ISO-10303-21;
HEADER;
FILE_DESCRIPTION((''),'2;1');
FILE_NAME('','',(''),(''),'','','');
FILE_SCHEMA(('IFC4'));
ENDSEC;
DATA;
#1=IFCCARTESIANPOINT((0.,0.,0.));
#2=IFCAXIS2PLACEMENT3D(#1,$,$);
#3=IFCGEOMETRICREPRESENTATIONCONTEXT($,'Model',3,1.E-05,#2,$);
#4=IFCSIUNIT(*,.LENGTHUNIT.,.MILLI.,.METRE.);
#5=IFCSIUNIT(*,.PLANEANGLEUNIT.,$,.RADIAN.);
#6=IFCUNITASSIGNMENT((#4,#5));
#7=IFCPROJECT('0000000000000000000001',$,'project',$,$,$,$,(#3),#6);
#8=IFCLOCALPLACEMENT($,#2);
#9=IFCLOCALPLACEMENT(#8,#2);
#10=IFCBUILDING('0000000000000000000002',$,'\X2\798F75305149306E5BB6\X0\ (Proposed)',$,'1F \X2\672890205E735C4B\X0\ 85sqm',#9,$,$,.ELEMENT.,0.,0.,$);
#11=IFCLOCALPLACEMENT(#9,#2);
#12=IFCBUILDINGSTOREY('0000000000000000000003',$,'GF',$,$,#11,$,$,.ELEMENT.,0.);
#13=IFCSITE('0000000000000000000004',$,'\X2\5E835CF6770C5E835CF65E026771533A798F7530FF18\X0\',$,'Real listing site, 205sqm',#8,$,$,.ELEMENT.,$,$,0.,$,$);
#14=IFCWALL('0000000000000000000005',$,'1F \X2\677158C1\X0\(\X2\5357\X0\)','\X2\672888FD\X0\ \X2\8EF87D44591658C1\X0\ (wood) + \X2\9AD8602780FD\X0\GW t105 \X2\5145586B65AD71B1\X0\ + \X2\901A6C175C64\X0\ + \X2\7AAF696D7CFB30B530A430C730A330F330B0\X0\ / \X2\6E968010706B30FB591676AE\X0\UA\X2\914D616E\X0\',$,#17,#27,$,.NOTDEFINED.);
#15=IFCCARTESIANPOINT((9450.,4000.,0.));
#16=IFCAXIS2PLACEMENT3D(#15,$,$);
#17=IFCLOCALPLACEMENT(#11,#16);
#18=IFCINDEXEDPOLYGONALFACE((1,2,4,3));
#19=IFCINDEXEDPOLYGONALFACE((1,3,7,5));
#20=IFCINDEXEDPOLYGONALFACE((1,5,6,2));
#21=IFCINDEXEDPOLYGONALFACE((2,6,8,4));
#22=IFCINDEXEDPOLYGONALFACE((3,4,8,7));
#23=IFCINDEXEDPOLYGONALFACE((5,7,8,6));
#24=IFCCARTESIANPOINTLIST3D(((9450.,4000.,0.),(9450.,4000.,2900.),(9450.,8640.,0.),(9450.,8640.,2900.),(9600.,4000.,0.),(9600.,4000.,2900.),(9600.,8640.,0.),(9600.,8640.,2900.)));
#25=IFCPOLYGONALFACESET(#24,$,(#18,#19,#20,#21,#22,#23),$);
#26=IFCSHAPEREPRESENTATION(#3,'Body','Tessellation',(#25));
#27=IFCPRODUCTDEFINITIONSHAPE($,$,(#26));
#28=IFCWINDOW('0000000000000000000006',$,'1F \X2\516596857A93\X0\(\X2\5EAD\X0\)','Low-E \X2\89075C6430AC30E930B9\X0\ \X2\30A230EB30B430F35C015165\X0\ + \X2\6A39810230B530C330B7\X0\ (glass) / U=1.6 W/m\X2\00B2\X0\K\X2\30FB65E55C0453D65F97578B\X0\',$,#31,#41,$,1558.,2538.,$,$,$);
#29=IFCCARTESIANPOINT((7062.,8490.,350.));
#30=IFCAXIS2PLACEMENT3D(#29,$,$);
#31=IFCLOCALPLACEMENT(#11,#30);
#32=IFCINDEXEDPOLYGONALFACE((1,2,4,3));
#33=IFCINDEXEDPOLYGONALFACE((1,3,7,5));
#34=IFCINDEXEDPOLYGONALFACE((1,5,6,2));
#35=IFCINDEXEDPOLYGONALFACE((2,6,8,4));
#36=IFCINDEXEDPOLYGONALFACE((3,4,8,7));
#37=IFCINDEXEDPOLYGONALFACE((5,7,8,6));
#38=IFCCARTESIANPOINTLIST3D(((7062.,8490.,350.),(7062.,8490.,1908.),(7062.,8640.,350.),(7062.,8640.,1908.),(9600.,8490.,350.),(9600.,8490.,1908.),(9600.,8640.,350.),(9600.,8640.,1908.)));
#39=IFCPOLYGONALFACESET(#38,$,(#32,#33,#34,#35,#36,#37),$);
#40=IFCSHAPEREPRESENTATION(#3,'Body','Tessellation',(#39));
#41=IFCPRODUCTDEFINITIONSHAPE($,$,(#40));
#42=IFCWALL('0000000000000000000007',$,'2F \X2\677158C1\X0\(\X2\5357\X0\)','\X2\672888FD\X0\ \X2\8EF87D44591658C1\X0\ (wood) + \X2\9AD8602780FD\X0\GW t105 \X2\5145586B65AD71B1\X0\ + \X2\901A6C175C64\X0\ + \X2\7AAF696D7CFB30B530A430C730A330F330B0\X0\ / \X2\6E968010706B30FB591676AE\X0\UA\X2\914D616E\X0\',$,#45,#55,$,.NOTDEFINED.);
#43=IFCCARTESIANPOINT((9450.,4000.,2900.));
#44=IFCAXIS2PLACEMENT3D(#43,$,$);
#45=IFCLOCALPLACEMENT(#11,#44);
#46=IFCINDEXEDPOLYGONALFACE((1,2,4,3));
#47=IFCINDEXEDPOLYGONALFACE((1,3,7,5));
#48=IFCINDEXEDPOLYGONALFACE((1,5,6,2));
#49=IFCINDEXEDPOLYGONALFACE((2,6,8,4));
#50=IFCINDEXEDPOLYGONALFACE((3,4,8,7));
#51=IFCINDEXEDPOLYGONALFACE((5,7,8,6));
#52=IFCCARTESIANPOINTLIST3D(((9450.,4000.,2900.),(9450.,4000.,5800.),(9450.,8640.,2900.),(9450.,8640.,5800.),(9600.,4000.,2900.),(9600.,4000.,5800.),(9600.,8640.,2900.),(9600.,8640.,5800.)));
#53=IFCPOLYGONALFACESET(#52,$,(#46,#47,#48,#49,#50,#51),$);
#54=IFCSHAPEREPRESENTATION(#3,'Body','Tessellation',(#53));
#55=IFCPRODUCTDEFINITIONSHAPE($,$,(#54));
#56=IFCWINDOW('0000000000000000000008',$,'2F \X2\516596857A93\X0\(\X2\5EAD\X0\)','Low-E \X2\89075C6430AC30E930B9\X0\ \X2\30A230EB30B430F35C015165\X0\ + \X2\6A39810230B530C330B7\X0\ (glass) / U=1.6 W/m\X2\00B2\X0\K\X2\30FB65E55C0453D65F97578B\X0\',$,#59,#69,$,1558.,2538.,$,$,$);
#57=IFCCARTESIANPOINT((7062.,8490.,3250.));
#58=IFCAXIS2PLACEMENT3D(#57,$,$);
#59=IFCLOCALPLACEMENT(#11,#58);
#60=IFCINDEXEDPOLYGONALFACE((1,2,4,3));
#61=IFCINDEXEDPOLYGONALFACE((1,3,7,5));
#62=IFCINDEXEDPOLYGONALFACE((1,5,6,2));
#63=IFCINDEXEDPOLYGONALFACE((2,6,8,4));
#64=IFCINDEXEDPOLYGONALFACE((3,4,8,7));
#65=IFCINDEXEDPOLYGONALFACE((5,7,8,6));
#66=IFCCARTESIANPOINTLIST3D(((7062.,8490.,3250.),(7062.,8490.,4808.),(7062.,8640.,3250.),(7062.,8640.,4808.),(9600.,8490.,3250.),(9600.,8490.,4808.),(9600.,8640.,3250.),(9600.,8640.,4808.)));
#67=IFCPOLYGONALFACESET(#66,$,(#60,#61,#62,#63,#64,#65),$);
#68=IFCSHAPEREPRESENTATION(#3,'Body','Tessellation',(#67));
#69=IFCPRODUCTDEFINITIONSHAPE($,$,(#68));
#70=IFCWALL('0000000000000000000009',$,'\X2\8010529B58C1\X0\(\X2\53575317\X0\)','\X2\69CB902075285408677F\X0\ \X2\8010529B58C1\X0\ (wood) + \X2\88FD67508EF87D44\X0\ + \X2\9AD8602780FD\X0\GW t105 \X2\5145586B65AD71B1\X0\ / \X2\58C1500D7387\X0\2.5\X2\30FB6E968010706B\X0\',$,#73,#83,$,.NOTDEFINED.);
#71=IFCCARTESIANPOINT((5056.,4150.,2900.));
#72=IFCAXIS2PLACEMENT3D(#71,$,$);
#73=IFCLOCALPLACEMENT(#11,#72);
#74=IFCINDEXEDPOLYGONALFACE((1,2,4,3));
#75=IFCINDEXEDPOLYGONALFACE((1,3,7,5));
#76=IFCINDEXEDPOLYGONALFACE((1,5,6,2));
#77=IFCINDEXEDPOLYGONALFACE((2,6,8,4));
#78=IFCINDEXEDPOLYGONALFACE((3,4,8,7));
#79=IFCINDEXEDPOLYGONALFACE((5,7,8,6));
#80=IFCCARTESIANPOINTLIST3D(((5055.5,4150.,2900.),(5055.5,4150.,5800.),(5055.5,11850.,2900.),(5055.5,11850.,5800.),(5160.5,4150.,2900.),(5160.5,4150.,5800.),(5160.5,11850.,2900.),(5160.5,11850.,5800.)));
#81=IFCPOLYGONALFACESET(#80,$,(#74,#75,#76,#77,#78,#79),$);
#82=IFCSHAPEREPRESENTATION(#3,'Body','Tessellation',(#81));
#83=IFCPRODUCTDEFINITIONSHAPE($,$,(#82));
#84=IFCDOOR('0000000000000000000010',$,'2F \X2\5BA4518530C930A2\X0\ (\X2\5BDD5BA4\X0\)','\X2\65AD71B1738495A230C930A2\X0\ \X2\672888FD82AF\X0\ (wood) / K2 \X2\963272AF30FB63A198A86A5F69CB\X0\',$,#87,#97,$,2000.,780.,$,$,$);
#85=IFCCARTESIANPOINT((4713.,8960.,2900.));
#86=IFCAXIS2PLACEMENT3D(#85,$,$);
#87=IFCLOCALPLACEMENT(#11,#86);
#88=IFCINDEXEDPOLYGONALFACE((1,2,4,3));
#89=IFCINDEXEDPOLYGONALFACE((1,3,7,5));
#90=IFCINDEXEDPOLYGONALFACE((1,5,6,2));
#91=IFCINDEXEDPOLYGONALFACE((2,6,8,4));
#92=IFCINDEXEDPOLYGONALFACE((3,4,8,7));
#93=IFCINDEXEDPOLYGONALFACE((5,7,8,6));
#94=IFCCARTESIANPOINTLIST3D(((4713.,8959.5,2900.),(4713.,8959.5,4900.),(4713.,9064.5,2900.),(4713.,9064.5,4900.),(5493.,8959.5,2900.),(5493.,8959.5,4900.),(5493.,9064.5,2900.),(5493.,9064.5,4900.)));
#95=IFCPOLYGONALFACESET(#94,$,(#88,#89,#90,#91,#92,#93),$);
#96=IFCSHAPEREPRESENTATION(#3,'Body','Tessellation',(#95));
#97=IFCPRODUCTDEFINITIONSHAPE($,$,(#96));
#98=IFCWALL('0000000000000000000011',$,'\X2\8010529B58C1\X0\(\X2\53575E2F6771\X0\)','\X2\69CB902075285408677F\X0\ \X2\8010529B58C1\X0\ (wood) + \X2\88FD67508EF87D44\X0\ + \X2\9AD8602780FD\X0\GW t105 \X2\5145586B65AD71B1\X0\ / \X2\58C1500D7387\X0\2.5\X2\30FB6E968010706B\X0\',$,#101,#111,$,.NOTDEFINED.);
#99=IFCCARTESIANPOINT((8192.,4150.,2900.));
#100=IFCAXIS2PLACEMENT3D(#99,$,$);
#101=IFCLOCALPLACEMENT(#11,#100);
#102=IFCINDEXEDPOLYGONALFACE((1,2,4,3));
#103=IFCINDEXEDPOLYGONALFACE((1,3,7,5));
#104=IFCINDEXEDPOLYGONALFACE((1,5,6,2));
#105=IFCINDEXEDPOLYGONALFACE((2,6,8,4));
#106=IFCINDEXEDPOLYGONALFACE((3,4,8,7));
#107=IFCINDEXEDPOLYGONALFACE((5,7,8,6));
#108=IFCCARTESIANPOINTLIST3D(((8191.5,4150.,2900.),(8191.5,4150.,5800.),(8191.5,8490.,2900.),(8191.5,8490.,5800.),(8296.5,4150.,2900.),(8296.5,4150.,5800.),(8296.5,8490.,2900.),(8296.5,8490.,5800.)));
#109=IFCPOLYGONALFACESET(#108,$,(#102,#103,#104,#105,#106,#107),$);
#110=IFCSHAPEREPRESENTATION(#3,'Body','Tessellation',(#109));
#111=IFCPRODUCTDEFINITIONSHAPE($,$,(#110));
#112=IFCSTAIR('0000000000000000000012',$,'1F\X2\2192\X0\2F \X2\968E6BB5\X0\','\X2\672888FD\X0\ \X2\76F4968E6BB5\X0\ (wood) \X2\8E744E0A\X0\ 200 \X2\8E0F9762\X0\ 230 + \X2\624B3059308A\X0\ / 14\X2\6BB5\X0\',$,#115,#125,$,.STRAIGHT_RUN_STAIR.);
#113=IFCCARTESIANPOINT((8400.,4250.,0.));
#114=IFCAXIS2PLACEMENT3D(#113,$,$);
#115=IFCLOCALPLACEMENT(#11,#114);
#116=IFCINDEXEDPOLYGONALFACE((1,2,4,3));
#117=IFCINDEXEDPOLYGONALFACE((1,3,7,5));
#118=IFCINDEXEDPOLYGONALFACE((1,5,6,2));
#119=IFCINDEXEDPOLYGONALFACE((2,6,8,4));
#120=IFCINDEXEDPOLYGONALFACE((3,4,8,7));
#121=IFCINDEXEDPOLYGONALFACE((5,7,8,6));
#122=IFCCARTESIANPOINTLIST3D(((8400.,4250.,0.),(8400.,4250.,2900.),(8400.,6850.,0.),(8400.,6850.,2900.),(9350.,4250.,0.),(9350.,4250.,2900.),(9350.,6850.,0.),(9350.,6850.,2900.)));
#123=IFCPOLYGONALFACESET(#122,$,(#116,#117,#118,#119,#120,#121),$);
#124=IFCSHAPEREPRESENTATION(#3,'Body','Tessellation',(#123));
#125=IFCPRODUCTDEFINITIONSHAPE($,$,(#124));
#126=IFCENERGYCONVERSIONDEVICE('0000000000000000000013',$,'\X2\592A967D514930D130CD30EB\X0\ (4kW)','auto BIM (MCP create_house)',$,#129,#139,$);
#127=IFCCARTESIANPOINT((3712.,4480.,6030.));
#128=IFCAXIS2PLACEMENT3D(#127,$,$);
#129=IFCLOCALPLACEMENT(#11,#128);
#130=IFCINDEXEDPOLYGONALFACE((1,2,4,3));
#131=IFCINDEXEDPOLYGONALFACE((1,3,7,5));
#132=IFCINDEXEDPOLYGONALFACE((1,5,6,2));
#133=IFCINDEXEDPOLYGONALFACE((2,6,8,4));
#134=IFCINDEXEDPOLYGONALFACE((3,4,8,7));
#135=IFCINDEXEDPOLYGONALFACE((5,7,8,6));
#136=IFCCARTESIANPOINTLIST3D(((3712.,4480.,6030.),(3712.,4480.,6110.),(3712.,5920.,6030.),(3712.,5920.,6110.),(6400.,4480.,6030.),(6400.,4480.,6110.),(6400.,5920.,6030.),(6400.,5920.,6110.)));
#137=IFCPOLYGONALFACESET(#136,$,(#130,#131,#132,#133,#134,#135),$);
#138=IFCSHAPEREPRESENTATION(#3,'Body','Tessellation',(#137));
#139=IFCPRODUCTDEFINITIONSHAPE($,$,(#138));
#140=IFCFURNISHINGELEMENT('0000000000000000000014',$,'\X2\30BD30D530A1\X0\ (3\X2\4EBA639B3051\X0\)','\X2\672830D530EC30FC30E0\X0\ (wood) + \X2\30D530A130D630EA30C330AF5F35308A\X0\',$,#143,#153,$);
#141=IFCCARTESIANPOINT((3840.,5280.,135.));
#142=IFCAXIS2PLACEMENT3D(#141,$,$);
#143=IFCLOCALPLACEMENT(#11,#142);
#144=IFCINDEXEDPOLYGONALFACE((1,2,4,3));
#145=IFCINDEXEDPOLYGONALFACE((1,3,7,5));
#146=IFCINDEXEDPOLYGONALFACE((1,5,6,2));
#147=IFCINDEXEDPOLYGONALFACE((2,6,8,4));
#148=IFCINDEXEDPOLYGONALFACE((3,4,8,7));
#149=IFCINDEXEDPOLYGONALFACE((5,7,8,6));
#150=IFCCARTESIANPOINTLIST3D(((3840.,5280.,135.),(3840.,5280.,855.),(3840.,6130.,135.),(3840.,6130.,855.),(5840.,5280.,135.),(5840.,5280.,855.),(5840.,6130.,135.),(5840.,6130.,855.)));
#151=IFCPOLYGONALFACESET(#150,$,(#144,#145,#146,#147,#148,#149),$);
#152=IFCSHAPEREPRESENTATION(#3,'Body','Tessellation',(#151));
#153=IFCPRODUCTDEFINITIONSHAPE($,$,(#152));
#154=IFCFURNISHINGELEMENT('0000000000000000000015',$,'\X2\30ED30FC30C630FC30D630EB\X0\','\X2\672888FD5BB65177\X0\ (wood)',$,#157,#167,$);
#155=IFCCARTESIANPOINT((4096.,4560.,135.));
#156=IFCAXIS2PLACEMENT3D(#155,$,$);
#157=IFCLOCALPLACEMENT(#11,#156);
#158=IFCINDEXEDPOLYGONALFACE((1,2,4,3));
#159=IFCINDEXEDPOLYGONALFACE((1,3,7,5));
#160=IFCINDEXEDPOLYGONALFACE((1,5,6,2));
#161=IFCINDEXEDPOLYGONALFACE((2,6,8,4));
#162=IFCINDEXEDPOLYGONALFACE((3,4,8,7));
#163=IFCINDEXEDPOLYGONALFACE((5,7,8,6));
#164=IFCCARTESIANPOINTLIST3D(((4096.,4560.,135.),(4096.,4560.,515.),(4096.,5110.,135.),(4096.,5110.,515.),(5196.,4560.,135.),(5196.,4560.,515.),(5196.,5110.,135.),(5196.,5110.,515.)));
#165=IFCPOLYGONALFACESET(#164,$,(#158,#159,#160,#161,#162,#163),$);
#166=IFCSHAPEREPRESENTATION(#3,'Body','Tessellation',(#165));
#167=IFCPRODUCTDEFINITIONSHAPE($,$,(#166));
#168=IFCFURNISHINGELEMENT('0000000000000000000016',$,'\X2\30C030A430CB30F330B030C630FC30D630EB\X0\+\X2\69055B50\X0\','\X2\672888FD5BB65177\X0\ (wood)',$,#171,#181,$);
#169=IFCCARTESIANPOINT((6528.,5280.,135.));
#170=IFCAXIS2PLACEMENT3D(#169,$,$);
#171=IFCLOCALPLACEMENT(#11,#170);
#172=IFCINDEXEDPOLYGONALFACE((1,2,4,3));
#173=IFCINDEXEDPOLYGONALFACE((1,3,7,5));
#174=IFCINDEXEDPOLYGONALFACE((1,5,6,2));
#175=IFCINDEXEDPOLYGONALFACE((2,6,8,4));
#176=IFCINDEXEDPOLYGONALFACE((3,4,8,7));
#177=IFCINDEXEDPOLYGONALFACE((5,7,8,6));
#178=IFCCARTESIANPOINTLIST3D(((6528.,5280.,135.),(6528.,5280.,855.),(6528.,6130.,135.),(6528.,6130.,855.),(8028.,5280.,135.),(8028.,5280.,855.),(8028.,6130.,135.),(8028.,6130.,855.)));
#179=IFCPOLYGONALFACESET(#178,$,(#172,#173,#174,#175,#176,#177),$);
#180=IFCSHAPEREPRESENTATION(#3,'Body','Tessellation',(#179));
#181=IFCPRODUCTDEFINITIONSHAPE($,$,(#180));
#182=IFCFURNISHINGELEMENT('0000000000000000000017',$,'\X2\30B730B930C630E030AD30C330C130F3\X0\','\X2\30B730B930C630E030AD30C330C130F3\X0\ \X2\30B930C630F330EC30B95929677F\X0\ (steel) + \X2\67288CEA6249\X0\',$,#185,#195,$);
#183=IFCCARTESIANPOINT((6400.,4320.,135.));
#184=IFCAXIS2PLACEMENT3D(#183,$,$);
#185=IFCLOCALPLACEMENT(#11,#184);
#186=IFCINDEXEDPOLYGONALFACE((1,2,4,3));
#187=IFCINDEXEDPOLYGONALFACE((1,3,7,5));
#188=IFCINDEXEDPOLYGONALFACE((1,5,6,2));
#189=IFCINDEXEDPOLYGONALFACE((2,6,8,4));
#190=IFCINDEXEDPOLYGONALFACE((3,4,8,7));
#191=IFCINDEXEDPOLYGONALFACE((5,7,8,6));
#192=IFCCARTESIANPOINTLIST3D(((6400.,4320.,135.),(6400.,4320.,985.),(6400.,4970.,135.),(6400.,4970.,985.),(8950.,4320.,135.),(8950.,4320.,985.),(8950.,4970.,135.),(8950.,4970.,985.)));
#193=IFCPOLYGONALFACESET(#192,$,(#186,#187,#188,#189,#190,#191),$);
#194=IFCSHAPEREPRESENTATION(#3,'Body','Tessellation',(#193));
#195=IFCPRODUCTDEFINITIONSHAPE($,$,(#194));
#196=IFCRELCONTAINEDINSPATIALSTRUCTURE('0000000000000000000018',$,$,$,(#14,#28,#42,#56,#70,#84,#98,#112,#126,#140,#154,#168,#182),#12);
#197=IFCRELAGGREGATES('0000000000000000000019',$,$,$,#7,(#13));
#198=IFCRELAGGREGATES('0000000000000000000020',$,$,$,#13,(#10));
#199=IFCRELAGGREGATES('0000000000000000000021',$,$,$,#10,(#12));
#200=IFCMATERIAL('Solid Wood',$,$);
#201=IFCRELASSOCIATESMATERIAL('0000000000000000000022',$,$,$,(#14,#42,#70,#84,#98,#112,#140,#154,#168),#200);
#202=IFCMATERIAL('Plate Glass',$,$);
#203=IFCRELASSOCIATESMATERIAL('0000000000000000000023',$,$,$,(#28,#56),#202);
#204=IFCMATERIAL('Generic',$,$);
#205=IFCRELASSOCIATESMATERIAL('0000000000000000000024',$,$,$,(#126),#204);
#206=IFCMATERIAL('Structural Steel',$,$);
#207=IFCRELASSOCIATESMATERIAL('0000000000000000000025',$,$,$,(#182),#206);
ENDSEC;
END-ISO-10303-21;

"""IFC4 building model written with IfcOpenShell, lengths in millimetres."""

from ifc_helpers import new_model, si_unit, frame, frame_2d, origin, place, context, project, spatial, rectangle, extrude, material, element, fill, save


model = new_model("IFC4")

# Units and contexts
model_context = context("Model", 3, precision=1e-05, world=origin())
ifc_project = project(units=[si_unit("LENGTHUNIT", "METRE", prefix="MILLI"), si_unit("PLANEANGLEUNIT", "RADIAN")], contexts=[model_context])

# Site, building, storey
site_placement = place(None, origin())
site = spatial("IfcSite", under=ifc_project, at=site_placement, Name="広島県広島市東区福田８", ObjectType="Real listing site, 205sqm", CompositionType="ELEMENT", RefElevation=0.0)
building_placement = place(site_placement, origin())
building = spatial("IfcBuilding", under=site, at=building_placement, Name="福田光の家 (Proposed)", ObjectType="1F 木造平屋 85sqm", CompositionType="ELEMENT", ElevationOfRefHeight=0.0, ElevationOfTerrain=0.0)
storey_placement = place(building_placement, origin())
storey = spatial("IfcBuildingStorey", under=building, at=storey_placement, Name="GF", CompositionType="ELEMENT", Elevation=0.0)

# Wall, opening, window
ifc_material_1 = material(Name="Solid Wood")
wall_1_placement = place(storey_placement, frame((9450.0, 4000.0, 0.0)))
wall_1 = element("IfcWall", 1, at=wall_1_placement, inside=storey, material=ifc_material_1, Name="1F 東壁(南)", Description="木製 軸組外壁 (wood) + 高性能GW t105 充填断熱 + 通気層 + 窯業系サイディング / 準耐火・外皮UA配慮", PredefinedType="NOTDEFINED", context=model_context, shape_type="SweptSolid", body=[
    extrude(rectangle(XDim=150.0, YDim=4640.0, at=frame_2d((75.0, 2320.0))), frame((9450.0, 4000.0, 0.0)), (0.0, 0.0, 1.0), 2900.0),
])
opening_1_placement = place(storey_placement, frame((7062.0, 8490.0, 350.0)))
opening_1 = element("IfcOpeningElement", 2, at=opening_1_placement, cuts=wall_1, PredefinedType="NOTDEFINED", context=model_context, shape_type="SweptSolid", body=[
    extrude(rectangle(XDim=2538.0, YDim=150.0, at=frame_2d((1269.0, 75.0))), frame((7062.0, 8490.0, 350.0)), (0.0, 0.0, 1.0), 1558.0),
])
ifc_material_2 = material(Name="Plate Glass")
window_1_placement = place(storey_placement, frame((7062.0, 8490.0, 350.0)))
window_1 = element("IfcWindow", 3, at=window_1_placement, inside=storey, material=ifc_material_2, Name="1F 入隅窓(庭)", Description="Low-E 複層ガラス アルゴン封入 + 樹脂サッシ (glass) / U=1.6 W/m²K・日射取得型", OverallHeight=1558.0, OverallWidth=2538.0, context=model_context, shape_type="SweptSolid", body=[
    extrude(rectangle(XDim=2538.0, YDim=150.0, at=frame_2d((1269.0, 75.0))), frame((7062.0, 8490.0, 350.0)), (0.0, 0.0, 1.0), 1558.0),
])
fill(opening_1, window_1)

# Wall, opening, window
wall_2_placement = place(storey_placement, frame((9450.0, 4000.0, 2900.0)))
wall_2 = element("IfcWall", 4, at=wall_2_placement, inside=storey, material=ifc_material_1, Name="2F 東壁(南)", Description="木製 軸組外壁 (wood) + 高性能GW t105 充填断熱 + 通気層 + 窯業系サイディング / 準耐火・外皮UA配慮", PredefinedType="NOTDEFINED", context=model_context, shape_type="SweptSolid", body=[
    extrude(rectangle(XDim=150.0, YDim=4640.0, at=frame_2d((75.0, 2320.0))), frame((9450.0, 4000.0, 2900.0)), (0.0, 0.0, 1.0), 2900.0),
])
opening_2_placement = place(storey_placement, frame((7062.0, 8490.0, 3250.0)))
opening_2 = element("IfcOpeningElement", 5, at=opening_2_placement, cuts=wall_2, PredefinedType="NOTDEFINED", context=model_context, shape_type="SweptSolid", body=[
    extrude(rectangle(XDim=2538.0, YDim=150.0, at=frame_2d((1269.0, 75.0))), frame((7062.0, 8490.0, 3250.0)), (0.0, 0.0, 1.0), 1558.0),
])
window_2_placement = place(storey_placement, frame((7062.0, 8490.0, 3250.0)))
window_2 = element("IfcWindow", 6, at=window_2_placement, inside=storey, material=ifc_material_2, Name="2F 入隅窓(庭)", Description="Low-E 複層ガラス アルゴン封入 + 樹脂サッシ (glass) / U=1.6 W/m²K・日射取得型", OverallHeight=1558.0, OverallWidth=2538.0, context=model_context, shape_type="SweptSolid", body=[
    extrude(rectangle(XDim=2538.0, YDim=150.0, at=frame_2d((1269.0, 75.0))), frame((7062.0, 8490.0, 3250.0)), (0.0, 0.0, 1.0), 1558.0),
])
fill(opening_2, window_2)

# Wall, opening, door
wall_3_placement = place(storey_placement, frame((5056.0, 4150.0, 2900.0)))
wall_3 = element("IfcWall", 7, at=wall_3_placement, inside=storey, material=ifc_material_1, Name="耐力壁(南北)", Description="構造用合板 耐力壁 (wood) + 製材軸組 + 高性能GW t105 充填断熱 / 壁倍率2.5・準耐火", PredefinedType="NOTDEFINED", context=model_context, shape_type="SweptSolid", body=[
    extrude(rectangle(XDim=105.0, YDim=7700.0, at=frame_2d((52.0, 3850.0))), frame((5056.0, 4150.0, 2900.0)), (0.0, 0.0, 1.0), 2900.0),
])
opening_3_placement = place(storey_placement, frame((4713.0, 8960.0, 2900.0)))
opening_3 = element("IfcOpeningElement", 8, at=opening_3_placement, cuts=wall_3, PredefinedType="NOTDEFINED", context=model_context, shape_type="SweptSolid", body=[
    extrude(rectangle(XDim=780.0, YDim=105.0, at=frame_2d((390.0, 52.0))), frame((4713.0, 8960.0, 2900.0)), (0.0, 0.0, 1.0), 2000.0),
])
door_1_placement = place(storey_placement, frame((4713.0, 8960.0, 2900.0)))
door_1 = element("IfcDoor", 9, at=door_1_placement, inside=storey, material=ifc_material_1, Name="2F 室内ドア (寝室)", Description="断熱玄関ドア 木製芯 (wood) / K2 防犯・採風機構", OverallHeight=2000.0, OverallWidth=780.0, context=model_context, shape_type="SweptSolid", body=[
    extrude(rectangle(XDim=780.0, YDim=105.0, at=frame_2d((390.0, 52.0))), frame((4713.0, 8960.0, 2900.0)), (0.0, 0.0, 1.0), 2000.0),
])
fill(opening_3, door_1)

# Wall
wall_4_placement = place(storey_placement, frame((8192.0, 4150.0, 2900.0)))
element("IfcWall", 10, at=wall_4_placement, inside=storey, material=ifc_material_1, Name="耐力壁(南帯東)", Description="構造用合板 耐力壁 (wood) + 製材軸組 + 高性能GW t105 充填断熱 / 壁倍率2.5・準耐火", PredefinedType="NOTDEFINED", context=model_context, shape_type="SweptSolid", body=[
    extrude(rectangle(XDim=105.0, YDim=4340.0, at=frame_2d((52.0, 2170.0))), frame((8192.0, 4150.0, 2900.0)), (0.0, 0.0, 1.0), 2900.0),
])

# Stair
stair_placement = place(storey_placement, frame((8400.0, 4250.0, 0.0)))
element("IfcStair", 11, at=stair_placement, inside=storey, material=ifc_material_1, Name="1F→2F 階段", Description="木製 直階段 (wood) 蹴上 200 踏面 230 + 手すり / 14段", PredefinedType="STRAIGHT_RUN_STAIR", context=model_context, shape_type="SweptSolid", body=[
    extrude(rectangle(XDim=950.0, YDim=2600.0, at=frame_2d((475.0, 1300.0))), frame((8400.0, 4250.0, 0.0)), (0.0, 0.0, 1.0), 2900.0),
])

# Energy conversion device
ifc_material_3 = material(Name="Generic")
energy_conversion_device_placement = place(storey_placement, frame((3712.0, 4480.0, 6030.0)))
element("IfcEnergyConversionDevice", 12, at=energy_conversion_device_placement, inside=storey, material=ifc_material_3, Name="太陽光パネル (4kW)", Description="auto BIM (MCP create_house)", context=model_context, shape_type="SweptSolid", body=[
    extrude(rectangle(XDim=2688.0, YDim=1440.0, at=frame_2d((1344.0, 720.0))), frame((3712.0, 4480.0, 6030.0)), (0.0, 0.0, 1.0), 80.0),
])

# Furnishing elements
furnishing_1_placement = place(storey_placement, frame((3840.0, 5280.0, 135.0)))
element("IfcFurnishingElement", 13, at=furnishing_1_placement, inside=storey, material=ifc_material_1, Name="ソファ (3人掛け)", Description="木フレーム (wood) + ファブリック張り", context=model_context, shape_type="SweptSolid", body=[
    extrude(rectangle(XDim=2000.0, YDim=850.0, at=frame_2d((1000.0, 425.0))), frame((3840.0, 5280.0, 135.0)), (0.0, 0.0, 1.0), 720.0),
])
furnishing_2_placement = place(storey_placement, frame((4096.0, 4560.0, 135.0)))
element("IfcFurnishingElement", 14, at=furnishing_2_placement, inside=storey, material=ifc_material_1, Name="ローテーブル", Description="木製家具 (wood)", context=model_context, shape_type="SweptSolid", body=[
    extrude(rectangle(XDim=1100.0, YDim=550.0, at=frame_2d((550.0, 275.0))), frame((4096.0, 4560.0, 135.0)), (0.0, 0.0, 1.0), 380.0),
])
furnishing_3_placement = place(storey_placement, frame((6528.0, 5280.0, 135.0)))
element("IfcFurnishingElement", 15, at=furnishing_3_placement, inside=storey, material=ifc_material_1, Name="ダイニングテーブル+椅子", Description="木製家具 (wood)", context=model_context, shape_type="SweptSolid", body=[
    extrude(rectangle(XDim=1500.0, YDim=850.0, at=frame_2d((750.0, 425.0))), frame((6528.0, 5280.0, 135.0)), (0.0, 0.0, 1.0), 720.0),
])
ifc_material_4 = material(Name="Structural Steel")
furnishing_4_placement = place(storey_placement, frame((6400.0, 4320.0, 135.0)))
element("IfcFurnishingElement", 16, at=furnishing_4_placement, inside=storey, material=ifc_material_4, Name="システムキッチン", Description="システムキッチン ステンレス天板 (steel) + 木質扉", context=model_context, shape_type="SweptSolid", body=[
    extrude(rectangle(XDim=2550.0, YDim=650.0, at=frame_2d((1275.0, 325.0))), frame((6400.0, 4320.0, 135.0)), (0.0, 0.0, 1.0), 850.0),
])

save(model, "model.ifc")
